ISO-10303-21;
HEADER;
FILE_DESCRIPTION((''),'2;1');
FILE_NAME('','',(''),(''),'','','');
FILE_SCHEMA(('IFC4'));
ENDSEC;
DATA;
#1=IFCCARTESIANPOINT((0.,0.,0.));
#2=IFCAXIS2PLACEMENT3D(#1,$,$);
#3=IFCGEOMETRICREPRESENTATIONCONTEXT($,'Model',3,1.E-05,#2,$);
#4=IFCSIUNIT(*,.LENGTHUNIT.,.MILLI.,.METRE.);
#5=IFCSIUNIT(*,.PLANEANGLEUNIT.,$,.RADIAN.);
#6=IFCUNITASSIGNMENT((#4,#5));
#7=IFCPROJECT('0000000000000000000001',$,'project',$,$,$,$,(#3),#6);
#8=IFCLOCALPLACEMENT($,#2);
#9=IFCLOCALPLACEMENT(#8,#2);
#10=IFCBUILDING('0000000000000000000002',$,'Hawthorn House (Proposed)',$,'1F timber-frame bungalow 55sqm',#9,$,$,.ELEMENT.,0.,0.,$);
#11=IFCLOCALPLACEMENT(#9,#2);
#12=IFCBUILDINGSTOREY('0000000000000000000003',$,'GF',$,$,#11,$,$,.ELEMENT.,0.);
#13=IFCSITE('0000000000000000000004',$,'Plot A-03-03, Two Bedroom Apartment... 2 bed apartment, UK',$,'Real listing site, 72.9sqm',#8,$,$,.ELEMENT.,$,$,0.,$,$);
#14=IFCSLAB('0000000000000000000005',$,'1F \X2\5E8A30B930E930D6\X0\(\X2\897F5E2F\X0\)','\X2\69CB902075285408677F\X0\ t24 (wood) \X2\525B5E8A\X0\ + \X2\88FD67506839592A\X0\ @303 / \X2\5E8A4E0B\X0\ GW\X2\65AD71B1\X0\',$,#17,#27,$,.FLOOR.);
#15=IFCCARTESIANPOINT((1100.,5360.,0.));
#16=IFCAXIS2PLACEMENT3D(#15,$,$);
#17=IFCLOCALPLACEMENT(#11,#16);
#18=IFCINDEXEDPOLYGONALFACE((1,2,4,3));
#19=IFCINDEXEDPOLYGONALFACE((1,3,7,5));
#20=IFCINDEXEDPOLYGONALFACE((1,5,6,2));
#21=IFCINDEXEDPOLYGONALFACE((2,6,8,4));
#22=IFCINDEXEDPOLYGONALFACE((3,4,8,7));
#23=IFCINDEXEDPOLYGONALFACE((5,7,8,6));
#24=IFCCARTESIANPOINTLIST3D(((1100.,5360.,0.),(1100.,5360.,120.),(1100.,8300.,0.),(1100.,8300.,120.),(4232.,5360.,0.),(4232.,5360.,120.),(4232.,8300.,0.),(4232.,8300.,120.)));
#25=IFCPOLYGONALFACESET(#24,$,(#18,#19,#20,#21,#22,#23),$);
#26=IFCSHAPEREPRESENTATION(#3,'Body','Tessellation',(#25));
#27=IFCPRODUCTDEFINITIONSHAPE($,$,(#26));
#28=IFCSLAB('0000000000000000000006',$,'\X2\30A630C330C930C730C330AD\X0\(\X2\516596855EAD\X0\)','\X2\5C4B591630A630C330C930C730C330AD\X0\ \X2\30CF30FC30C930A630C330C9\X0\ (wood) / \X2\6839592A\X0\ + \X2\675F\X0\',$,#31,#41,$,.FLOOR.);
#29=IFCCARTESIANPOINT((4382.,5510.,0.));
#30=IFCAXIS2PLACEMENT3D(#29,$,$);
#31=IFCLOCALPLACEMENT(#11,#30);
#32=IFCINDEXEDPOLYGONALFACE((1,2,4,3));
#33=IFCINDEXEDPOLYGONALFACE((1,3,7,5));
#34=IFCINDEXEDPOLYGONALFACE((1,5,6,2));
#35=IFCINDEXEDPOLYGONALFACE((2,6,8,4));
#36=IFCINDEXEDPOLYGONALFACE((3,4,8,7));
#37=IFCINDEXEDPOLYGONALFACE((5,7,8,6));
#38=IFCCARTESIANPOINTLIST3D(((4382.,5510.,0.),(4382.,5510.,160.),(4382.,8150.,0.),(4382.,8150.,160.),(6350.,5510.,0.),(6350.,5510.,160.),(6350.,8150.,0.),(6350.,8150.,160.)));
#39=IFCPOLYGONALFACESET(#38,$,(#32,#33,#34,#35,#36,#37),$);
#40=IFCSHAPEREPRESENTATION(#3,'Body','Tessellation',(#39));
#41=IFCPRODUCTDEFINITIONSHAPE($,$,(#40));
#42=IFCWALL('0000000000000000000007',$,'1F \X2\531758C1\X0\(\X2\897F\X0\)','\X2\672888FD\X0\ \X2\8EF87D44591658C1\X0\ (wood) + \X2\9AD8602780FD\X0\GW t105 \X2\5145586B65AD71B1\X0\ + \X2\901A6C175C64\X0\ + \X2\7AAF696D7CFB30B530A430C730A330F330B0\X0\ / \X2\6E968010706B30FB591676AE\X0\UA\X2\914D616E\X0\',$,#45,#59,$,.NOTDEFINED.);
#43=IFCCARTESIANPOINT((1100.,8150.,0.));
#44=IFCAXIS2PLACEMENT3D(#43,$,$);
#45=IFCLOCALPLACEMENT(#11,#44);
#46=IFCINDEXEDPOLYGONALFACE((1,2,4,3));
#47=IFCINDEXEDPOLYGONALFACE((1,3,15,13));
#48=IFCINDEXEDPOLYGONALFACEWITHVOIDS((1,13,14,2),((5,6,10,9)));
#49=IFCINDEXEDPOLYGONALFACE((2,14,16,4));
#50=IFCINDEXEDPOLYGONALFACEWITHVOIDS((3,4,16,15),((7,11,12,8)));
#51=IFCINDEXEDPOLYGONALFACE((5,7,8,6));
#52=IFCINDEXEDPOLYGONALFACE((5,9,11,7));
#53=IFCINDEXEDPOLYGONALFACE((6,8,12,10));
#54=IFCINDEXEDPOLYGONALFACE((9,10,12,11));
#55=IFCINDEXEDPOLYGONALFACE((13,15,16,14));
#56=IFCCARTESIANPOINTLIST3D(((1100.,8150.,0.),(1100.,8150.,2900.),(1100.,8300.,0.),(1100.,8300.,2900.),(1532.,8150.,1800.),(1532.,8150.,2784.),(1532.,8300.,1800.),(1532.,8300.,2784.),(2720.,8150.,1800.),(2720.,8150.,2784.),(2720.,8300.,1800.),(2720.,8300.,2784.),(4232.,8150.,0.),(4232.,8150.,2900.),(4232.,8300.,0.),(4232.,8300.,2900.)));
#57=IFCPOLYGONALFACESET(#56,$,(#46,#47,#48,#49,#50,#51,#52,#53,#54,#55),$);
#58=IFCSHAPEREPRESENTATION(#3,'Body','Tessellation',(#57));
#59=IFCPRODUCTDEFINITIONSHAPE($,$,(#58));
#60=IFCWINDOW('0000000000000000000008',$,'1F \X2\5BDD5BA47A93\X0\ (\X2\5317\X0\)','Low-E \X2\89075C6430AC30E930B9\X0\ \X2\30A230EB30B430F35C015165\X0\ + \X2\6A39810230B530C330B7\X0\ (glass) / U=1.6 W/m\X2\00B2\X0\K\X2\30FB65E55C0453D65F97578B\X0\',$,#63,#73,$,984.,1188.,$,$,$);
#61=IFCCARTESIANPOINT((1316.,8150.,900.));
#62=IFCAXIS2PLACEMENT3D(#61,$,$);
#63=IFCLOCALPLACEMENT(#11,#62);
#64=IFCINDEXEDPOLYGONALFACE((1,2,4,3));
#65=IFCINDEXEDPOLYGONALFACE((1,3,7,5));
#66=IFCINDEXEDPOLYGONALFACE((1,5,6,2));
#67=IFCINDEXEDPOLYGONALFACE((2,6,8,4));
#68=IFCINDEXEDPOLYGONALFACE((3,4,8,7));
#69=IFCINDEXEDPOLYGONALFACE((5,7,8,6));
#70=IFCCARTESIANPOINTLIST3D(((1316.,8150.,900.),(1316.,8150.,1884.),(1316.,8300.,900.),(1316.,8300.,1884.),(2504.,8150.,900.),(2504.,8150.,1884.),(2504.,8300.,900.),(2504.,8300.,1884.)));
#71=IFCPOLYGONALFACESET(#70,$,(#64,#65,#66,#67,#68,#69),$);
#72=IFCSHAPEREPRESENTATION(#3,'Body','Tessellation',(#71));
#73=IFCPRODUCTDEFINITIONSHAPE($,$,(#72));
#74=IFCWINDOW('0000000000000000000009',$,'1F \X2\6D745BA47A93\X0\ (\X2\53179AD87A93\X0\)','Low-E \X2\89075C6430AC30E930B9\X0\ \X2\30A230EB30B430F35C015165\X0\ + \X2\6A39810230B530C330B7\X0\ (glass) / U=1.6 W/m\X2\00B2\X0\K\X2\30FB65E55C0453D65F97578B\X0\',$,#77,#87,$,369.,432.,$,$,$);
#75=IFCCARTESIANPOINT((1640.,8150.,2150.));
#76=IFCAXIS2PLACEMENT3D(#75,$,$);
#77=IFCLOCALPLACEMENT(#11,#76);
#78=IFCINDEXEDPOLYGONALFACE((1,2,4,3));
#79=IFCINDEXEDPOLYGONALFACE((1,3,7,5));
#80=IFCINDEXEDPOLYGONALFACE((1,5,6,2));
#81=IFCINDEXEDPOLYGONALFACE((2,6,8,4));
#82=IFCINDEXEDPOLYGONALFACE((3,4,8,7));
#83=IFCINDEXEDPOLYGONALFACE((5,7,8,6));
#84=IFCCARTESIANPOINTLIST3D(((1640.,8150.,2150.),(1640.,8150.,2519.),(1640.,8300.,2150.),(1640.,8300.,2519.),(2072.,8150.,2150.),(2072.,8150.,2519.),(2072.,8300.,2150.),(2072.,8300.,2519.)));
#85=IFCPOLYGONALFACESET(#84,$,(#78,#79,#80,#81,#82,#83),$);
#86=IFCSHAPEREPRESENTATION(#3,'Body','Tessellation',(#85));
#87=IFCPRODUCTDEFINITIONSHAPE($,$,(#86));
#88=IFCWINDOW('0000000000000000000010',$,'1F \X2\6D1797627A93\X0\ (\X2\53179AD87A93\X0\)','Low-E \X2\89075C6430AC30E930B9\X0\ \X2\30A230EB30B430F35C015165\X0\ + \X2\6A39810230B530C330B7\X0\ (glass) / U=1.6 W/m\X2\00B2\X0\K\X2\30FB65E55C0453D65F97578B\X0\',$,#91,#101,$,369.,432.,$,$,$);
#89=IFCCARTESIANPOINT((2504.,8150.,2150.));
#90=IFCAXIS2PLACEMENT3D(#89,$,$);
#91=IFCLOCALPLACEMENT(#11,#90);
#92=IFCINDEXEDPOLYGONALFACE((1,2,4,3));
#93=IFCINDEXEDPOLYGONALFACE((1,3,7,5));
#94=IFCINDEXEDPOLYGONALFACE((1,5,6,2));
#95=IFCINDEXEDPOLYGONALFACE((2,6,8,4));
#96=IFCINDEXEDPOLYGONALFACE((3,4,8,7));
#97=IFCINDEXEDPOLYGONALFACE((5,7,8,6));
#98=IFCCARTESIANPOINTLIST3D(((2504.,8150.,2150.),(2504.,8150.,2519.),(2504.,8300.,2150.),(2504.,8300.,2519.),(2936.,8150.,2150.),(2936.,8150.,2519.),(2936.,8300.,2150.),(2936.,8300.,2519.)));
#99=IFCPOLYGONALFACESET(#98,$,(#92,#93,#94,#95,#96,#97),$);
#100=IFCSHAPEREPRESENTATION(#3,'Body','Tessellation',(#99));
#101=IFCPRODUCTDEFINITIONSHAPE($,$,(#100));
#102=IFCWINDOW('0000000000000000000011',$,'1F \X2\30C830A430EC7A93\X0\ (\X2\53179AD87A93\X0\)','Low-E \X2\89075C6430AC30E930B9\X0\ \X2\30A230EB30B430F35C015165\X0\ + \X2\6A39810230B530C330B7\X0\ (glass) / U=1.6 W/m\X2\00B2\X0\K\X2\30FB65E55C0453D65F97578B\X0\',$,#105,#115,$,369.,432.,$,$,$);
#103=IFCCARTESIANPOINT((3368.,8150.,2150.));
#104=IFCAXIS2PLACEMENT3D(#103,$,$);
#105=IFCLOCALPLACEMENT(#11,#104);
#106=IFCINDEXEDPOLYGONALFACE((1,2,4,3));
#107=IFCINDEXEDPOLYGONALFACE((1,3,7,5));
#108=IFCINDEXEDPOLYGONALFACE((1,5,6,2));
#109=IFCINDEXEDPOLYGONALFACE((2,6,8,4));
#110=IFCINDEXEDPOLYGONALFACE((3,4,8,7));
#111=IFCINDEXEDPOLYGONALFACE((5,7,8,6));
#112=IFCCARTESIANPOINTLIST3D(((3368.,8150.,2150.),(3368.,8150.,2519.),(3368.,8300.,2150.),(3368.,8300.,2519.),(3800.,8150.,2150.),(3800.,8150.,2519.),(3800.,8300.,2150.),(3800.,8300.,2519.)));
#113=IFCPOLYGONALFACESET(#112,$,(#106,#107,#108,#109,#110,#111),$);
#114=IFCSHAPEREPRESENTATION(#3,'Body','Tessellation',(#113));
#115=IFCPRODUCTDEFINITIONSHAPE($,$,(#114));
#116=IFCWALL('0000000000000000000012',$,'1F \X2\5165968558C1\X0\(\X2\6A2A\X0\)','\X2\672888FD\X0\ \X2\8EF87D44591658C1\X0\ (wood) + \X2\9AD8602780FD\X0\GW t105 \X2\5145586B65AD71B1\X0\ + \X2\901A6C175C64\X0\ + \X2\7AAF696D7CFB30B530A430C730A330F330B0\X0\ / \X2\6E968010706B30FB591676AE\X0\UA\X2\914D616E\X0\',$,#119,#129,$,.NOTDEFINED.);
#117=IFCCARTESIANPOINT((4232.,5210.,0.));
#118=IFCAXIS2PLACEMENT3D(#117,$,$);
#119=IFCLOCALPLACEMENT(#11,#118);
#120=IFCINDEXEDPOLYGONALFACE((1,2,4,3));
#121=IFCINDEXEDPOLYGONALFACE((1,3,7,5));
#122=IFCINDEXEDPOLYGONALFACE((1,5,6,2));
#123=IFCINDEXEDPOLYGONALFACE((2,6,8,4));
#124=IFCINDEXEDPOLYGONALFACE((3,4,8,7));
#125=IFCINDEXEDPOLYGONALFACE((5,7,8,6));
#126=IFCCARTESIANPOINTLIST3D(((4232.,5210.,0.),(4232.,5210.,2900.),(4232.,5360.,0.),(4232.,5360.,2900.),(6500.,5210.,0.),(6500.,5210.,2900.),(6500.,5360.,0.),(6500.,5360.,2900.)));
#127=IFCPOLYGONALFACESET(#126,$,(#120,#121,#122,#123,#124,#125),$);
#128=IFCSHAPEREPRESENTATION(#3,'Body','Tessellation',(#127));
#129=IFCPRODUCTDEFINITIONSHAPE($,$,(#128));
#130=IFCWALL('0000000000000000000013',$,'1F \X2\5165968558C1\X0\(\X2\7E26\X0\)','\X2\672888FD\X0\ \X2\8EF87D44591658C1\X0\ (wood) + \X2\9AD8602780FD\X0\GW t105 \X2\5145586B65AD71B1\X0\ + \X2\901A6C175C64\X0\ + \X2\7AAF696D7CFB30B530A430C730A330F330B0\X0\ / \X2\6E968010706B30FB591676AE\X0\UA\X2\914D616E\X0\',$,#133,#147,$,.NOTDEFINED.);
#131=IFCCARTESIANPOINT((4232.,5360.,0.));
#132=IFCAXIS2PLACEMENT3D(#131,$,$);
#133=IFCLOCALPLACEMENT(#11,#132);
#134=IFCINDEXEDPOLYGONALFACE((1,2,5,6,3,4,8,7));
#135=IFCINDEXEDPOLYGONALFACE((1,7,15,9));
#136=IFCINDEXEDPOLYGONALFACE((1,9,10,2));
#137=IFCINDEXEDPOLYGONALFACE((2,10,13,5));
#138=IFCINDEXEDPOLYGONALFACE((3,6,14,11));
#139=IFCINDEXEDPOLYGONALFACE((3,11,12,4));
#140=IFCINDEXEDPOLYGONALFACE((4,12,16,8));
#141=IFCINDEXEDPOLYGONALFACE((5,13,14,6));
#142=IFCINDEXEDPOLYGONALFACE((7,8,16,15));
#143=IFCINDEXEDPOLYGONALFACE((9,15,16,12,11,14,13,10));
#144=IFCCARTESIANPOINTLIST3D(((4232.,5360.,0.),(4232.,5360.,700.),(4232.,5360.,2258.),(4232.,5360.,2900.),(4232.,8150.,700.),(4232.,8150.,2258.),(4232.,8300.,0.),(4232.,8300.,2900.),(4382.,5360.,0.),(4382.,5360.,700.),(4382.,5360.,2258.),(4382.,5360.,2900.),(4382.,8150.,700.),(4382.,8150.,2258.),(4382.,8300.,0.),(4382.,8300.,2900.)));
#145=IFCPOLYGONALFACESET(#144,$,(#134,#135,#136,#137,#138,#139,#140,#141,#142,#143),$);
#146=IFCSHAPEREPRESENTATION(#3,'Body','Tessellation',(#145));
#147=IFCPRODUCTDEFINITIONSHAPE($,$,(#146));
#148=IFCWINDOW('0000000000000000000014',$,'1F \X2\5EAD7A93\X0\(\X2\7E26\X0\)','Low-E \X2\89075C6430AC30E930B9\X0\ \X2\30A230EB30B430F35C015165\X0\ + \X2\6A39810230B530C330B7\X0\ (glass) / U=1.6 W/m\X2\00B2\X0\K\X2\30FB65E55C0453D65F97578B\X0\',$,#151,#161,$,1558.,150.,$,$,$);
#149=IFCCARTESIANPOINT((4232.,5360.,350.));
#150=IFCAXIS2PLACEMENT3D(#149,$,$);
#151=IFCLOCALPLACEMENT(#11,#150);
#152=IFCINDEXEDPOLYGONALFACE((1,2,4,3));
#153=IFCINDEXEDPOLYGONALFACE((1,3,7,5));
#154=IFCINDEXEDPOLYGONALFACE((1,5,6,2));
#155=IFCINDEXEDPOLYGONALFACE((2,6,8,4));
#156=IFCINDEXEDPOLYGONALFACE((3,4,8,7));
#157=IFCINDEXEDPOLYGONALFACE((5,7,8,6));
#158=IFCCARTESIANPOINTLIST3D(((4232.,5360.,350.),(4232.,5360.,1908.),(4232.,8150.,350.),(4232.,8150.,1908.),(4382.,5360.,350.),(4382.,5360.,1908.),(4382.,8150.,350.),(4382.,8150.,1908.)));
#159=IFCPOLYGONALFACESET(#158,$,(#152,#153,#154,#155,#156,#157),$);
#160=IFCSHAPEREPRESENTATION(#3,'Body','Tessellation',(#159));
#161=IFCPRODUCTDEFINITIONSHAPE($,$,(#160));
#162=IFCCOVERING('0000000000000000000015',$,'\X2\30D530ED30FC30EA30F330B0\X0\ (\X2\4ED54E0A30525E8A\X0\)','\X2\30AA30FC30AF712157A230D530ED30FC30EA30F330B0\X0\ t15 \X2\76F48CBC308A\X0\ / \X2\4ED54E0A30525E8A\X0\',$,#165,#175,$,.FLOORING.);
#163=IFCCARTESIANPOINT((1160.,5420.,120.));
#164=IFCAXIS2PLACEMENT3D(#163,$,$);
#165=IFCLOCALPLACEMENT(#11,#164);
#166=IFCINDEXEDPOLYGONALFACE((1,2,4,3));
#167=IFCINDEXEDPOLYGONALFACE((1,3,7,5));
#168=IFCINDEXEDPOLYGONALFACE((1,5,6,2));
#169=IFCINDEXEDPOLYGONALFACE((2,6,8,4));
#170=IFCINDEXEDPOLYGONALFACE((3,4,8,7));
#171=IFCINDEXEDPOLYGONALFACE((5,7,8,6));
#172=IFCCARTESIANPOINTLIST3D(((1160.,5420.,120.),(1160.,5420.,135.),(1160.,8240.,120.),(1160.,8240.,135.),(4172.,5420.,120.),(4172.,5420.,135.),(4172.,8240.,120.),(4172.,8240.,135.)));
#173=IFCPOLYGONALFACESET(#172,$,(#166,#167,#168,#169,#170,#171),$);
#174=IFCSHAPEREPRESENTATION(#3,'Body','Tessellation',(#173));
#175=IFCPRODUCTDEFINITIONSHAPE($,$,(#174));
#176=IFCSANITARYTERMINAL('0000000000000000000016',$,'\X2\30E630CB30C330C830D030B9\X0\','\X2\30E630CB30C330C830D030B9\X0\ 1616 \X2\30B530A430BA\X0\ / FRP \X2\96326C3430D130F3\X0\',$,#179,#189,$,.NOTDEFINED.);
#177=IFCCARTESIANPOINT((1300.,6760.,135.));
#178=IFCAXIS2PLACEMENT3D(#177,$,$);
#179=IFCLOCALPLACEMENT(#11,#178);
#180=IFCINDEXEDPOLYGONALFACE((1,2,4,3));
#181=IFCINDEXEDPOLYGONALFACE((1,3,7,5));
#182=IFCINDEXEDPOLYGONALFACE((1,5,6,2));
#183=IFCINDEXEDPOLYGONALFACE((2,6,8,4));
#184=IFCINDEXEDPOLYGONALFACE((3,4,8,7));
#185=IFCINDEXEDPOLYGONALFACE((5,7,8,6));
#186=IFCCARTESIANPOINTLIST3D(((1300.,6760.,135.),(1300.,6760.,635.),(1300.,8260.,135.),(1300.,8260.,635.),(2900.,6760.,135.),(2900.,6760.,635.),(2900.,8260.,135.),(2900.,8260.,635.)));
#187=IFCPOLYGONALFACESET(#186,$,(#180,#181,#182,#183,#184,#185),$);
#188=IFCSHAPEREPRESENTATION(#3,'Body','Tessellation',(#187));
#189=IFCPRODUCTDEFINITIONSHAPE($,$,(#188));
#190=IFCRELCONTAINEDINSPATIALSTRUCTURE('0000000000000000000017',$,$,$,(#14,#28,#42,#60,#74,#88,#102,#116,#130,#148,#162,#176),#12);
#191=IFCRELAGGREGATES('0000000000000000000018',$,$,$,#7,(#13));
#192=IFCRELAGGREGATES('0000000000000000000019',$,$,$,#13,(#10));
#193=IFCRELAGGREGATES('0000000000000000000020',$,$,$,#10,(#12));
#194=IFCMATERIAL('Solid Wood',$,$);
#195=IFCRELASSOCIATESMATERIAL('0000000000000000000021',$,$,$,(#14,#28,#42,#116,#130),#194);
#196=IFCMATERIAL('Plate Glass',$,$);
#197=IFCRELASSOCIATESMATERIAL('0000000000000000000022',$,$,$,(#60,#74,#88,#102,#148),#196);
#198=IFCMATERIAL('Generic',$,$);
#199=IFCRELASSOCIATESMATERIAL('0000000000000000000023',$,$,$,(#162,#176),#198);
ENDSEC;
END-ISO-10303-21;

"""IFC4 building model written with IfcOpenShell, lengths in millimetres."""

from ifc_helpers import new_model, si_unit, frame, frame_2d, origin, place, context, project, spatial, rectangle, extrude, material, element, fill, save


model = new_model("IFC4")

# Units and contexts
model_context = context("Model", 3, precision=1e-05, world=origin())
ifc_project = project(units=[si_unit("LENGTHUNIT", "METRE", prefix="MILLI"), si_unit("PLANEANGLEUNIT", "RADIAN")], contexts=[model_context])

# Site, building, storey
site_placement = place(None, origin())
site = spatial("IfcSite", under=ifc_project, at=site_placement, Name="Plot A-03-03, Two Bedroom Apartment... 2 bed apartment, UK", ObjectType="Real listing site, 72.9sqm", CompositionType="ELEMENT", RefElevation=0.0)
building_placement = place(site_placement, origin())
building = spatial("IfcBuilding", under=site, at=building_placement, Name="Hawthorn House (Proposed)", ObjectType="1F timber-frame bungalow 55sqm", CompositionType="ELEMENT", ElevationOfRefHeight=0.0, ElevationOfTerrain=0.0)
storey_placement = place(building_placement, origin())
storey = spatial("IfcBuildingStorey", under=building, at=storey_placement, Name="GF", CompositionType="ELEMENT", Elevation=0.0)

# Slabs
ifc_material_1 = material(Name="Solid Wood")
slab_1_placement = place(storey_placement, frame((1100.0, 5360.0, 0.0)))
element("IfcSlab", 1, at=slab_1_placement, inside=storey, material=ifc_material_1, Name="1F 床スラブ(西帯)", Description="構造用合板 t24 (wood) 剛床 + 製材根太 @303 / 床下 GW断熱", PredefinedType="FLOOR", context=model_context, shape_type="SweptSolid", body=[
    extrude(rectangle(XDim=3132.0, YDim=2940.0, at=frame_2d((1566.0, 1470.0))), frame((1100.0, 5360.0, 0.0)), (0.0, 0.0, 1.0), 120.0),
])
slab_2_placement = place(storey_placement, frame((4382.0, 5510.0, 0.0)))
element("IfcSlab", 2, at=slab_2_placement, inside=storey, material=ifc_material_1, Name="ウッドデッキ(入隅庭)", Description="屋外ウッドデッキ ハードウッド (wood) / 根太 + 束", PredefinedType="FLOOR", context=model_context, shape_type="SweptSolid", body=[
    extrude(rectangle(XDim=1968.0, YDim=2640.0, at=frame_2d((984.0, 1320.0))), frame((4382.0, 5510.0, 0.0)), (0.0, 0.0, 1.0), 160.0),
])

# Wall, openings, windows
wall_1_placement = place(storey_placement, frame((1100.0, 8150.0, 0.0)))
wall_1 = element("IfcWall", 3, at=wall_1_placement, inside=storey, material=ifc_material_1, Name="1F 北壁(西)", Description="木製 軸組外壁 (wood) + 高性能GW t105 充填断熱 + 通気層 + 窯業系サイディング / 準耐火・外皮UA配慮", PredefinedType="NOTDEFINED", context=model_context, shape_type="SweptSolid", body=[
    extrude(rectangle(XDim=3132.0, YDim=150.0, at=frame_2d((1566.0, 75.0))), frame((1100.0, 8150.0, 0.0)), (0.0, 0.0, 1.0), 2900.0),
])
opening_1_placement = place(storey_placement, frame((1316.0, 8150.0, 900.0)))
opening_1 = element("IfcOpeningElement", 4, at=opening_1_placement, cuts=wall_1, PredefinedType="NOTDEFINED", context=model_context, shape_type="SweptSolid", body=[
    extrude(rectangle(XDim=1188.0, YDim=150.0, at=frame_2d((594.0, 75.0))), frame((1316.0, 8150.0, 900.0)), (0.0, 0.0, 1.0), 984.0),
])
opening_2_placement = place(storey_placement, frame((1640.0, 8150.0, 2150.0)))
opening_2 = element("IfcOpeningElement", 5, at=opening_2_placement, cuts=wall_1, PredefinedType="NOTDEFINED", context=model_context, shape_type="SweptSolid", body=[
    extrude(rectangle(XDim=432.0, YDim=150.0, at=frame_2d((216.0, 75.0))), frame((1640.0, 8150.0, 2150.0)), (0.0, 0.0, 1.0), 369.0),
])
opening_3_placement = place(storey_placement, frame((2504.0, 8150.0, 2150.0)))
opening_3 = element("IfcOpeningElement", 6, at=opening_3_placement, cuts=wall_1, PredefinedType="NOTDEFINED", context=model_context, shape_type="SweptSolid", body=[
    extrude(rectangle(XDim=432.0, YDim=150.0, at=frame_2d((216.0, 75.0))), frame((2504.0, 8150.0, 2150.0)), (0.0, 0.0, 1.0), 369.0),
])
opening_4_placement = place(storey_placement, frame((3368.0, 8150.0, 2150.0)))
opening_4 = element("IfcOpeningElement", 7, at=opening_4_placement, cuts=wall_1, PredefinedType="NOTDEFINED", context=model_context, shape_type="SweptSolid", body=[
    extrude(rectangle(XDim=432.0, YDim=150.0, at=frame_2d((216.0, 75.0))), frame((3368.0, 8150.0, 2150.0)), (0.0, 0.0, 1.0), 369.0),
])
ifc_material_2 = material(Name="Plate Glass")
window_1_placement = place(storey_placement, frame((1316.0, 8150.0, 900.0)))
window_1 = element("IfcWindow", 8, at=window_1_placement, inside=storey, material=ifc_material_2, Name="1F 寝室窓 (北)", Description="Low-E 複層ガラス アルゴン封入 + 樹脂サッシ (glass) / U=1.6 W/m²K・日射取得型", OverallHeight=984.0, OverallWidth=1188.0, context=model_context, shape_type="SweptSolid", body=[
    extrude(rectangle(XDim=1188.0, YDim=150.0, at=frame_2d((594.0, 75.0))), frame((1316.0, 8150.0, 900.0)), (0.0, 0.0, 1.0), 984.0),
])
fill(opening_1, window_1)
window_2_placement = place(storey_placement, frame((1640.0, 8150.0, 2150.0)))
window_2 = element("IfcWindow", 9, at=window_2_placement, inside=storey, material=ifc_material_2, Name="1F 浴室窓 (北高窓)", Description="Low-E 複層ガラス アルゴン封入 + 樹脂サッシ (glass) / U=1.6 W/m²K・日射取得型", OverallHeight=369.0, OverallWidth=432.0, context=model_context, shape_type="SweptSolid", body=[
    extrude(rectangle(XDim=432.0, YDim=150.0, at=frame_2d((216.0, 75.0))), frame((1640.0, 8150.0, 2150.0)), (0.0, 0.0, 1.0), 369.0),
])
fill(opening_2, window_2)
window_3_placement = place(storey_placement, frame((2504.0, 8150.0, 2150.0)))
window_3 = element("IfcWindow", 10, at=window_3_placement, inside=storey, material=ifc_material_2, Name="1F 洗面窓 (北高窓)", Description="Low-E 複層ガラス アルゴン封入 + 樹脂サッシ (glass) / U=1.6 W/m²K・日射取得型", OverallHeight=369.0, OverallWidth=432.0, context=model_context, shape_type="SweptSolid", body=[
    extrude(rectangle(XDim=432.0, YDim=150.0, at=frame_2d((216.0, 75.0))), frame((2504.0, 8150.0, 2150.0)), (0.0, 0.0, 1.0), 369.0),
])
fill(opening_3, window_3)
window_4_placement = place(storey_placement, frame((3368.0, 8150.0, 2150.0)))
window_4 = element("IfcWindow", 11, at=window_4_placement, inside=storey, material=ifc_material_2, Name="1F トイレ窓 (北高窓)", Description="Low-E 複層ガラス アルゴン封入 + 樹脂サッシ (glass) / U=1.6 W/m²K・日射取得型", OverallHeight=369.0, OverallWidth=432.0, context=model_context, shape_type="SweptSolid", body=[
    extrude(rectangle(XDim=432.0, YDim=150.0, at=frame_2d((216.0, 75.0))), frame((3368.0, 8150.0, 2150.0)), (0.0, 0.0, 1.0), 369.0),
])
fill(opening_4, window_4)

# Wall
wall_2_placement = place(storey_placement, frame((4232.0, 5210.0, 0.0)))
element("IfcWall", 12, at=wall_2_placement, inside=storey, material=ifc_material_1, Name="1F 入隅壁(横)", Description="木製 軸組外壁 (wood) + 高性能GW t105 充填断熱 + 通気層 + 窯業系サイディング / 準耐火・外皮UA配慮", PredefinedType="NOTDEFINED", context=model_context, shape_type="SweptSolid", body=[
    extrude(rectangle(XDim=2268.0, YDim=150.0, at=frame_2d((1134.0, 75.0))), frame((4232.0, 5210.0, 0.0)), (0.0, 0.0, 1.0), 2900.0),
])

# Wall, opening, window
wall_3_placement = place(storey_placement, frame((4232.0, 5360.0, 0.0)))
wall_3 = element("IfcWall", 13, at=wall_3_placement, inside=storey, material=ifc_material_1, Name="1F 入隅壁(縦)", Description="木製 軸組外壁 (wood) + 高性能GW t105 充填断熱 + 通気層 + 窯業系サイディング / 準耐火・外皮UA配慮", PredefinedType="NOTDEFINED", context=model_context, shape_type="SweptSolid", body=[
    extrude(rectangle(XDim=150.0, YDim=2940.0, at=frame_2d((75.0, 1470.0))), frame((4232.0, 5360.0, 0.0)), (0.0, 0.0, 1.0), 2900.0),
])
opening_5_placement = place(storey_placement, frame((4232.0, 5360.0, 350.0)))
opening_5 = element("IfcOpeningElement", 14, at=opening_5_placement, cuts=wall_3, PredefinedType="NOTDEFINED", context=model_context, shape_type="SweptSolid", body=[
    extrude(rectangle(XDim=150.0, YDim=2790.0, at=frame_2d((75.0, 1395.0))), frame((4232.0, 5360.0, 350.0)), (0.0, 0.0, 1.0), 1558.0),
])
window_5_placement = place(storey_placement, frame((4232.0, 5360.0, 350.0)))
window_5 = element("IfcWindow", 15, at=window_5_placement, inside=storey, material=ifc_material_2, Name="1F 庭窓(縦)", Description="Low-E 複層ガラス アルゴン封入 + 樹脂サッシ (glass) / U=1.6 W/m²K・日射取得型", OverallHeight=1558.0, OverallWidth=150.0, context=model_context, shape_type="SweptSolid", body=[
    extrude(rectangle(XDim=150.0, YDim=2790.0, at=frame_2d((75.0, 1395.0))), frame((4232.0, 5360.0, 350.0)), (0.0, 0.0, 1.0), 1558.0),
])
fill(opening_5, window_5)

# Covering
ifc_material_3 = material(Name="Generic")
covering_placement = place(storey_placement, frame((1160.0, 5420.0, 120.0)))
element("IfcCovering", 16, at=covering_placement, inside=storey, material=ifc_material_3, Name="フローリング (仕上げ床)", Description="オーク無垢フローリング t15 直貼り / 仕上げ床", PredefinedType="FLOORING", context=model_context, shape_type="SweptSolid", body=[
    extrude(rectangle(XDim=3012.0, YDim=2820.0, at=frame_2d((1506.0, 1410.0))), frame((1160.0, 5420.0, 120.0)), (0.0, 0.0, 1.0), 15.0),
])

# Sanitary terminal
sanitary_terminal_1_placement = place(storey_placement, frame((1300.0, 6760.0, 135.0)))
element("IfcSanitaryTerminal", 17, at=sanitary_terminal_1_placement, inside=storey, material=ifc_material_3, Name="ユニットバス", Description="ユニットバス 1616 サイズ / FRP 防水パン", PredefinedType="NOTDEFINED", context=model_context, shape_type="SweptSolid", body=[
    extrude(rectangle(XDim=1600.0, YDim=1500.0, at=frame_2d((800.0, 750.0))), frame((1300.0, 6760.0, 135.0)), (0.0, 0.0, 1.0), 500.0),
])

save(model, "model.ifc")
